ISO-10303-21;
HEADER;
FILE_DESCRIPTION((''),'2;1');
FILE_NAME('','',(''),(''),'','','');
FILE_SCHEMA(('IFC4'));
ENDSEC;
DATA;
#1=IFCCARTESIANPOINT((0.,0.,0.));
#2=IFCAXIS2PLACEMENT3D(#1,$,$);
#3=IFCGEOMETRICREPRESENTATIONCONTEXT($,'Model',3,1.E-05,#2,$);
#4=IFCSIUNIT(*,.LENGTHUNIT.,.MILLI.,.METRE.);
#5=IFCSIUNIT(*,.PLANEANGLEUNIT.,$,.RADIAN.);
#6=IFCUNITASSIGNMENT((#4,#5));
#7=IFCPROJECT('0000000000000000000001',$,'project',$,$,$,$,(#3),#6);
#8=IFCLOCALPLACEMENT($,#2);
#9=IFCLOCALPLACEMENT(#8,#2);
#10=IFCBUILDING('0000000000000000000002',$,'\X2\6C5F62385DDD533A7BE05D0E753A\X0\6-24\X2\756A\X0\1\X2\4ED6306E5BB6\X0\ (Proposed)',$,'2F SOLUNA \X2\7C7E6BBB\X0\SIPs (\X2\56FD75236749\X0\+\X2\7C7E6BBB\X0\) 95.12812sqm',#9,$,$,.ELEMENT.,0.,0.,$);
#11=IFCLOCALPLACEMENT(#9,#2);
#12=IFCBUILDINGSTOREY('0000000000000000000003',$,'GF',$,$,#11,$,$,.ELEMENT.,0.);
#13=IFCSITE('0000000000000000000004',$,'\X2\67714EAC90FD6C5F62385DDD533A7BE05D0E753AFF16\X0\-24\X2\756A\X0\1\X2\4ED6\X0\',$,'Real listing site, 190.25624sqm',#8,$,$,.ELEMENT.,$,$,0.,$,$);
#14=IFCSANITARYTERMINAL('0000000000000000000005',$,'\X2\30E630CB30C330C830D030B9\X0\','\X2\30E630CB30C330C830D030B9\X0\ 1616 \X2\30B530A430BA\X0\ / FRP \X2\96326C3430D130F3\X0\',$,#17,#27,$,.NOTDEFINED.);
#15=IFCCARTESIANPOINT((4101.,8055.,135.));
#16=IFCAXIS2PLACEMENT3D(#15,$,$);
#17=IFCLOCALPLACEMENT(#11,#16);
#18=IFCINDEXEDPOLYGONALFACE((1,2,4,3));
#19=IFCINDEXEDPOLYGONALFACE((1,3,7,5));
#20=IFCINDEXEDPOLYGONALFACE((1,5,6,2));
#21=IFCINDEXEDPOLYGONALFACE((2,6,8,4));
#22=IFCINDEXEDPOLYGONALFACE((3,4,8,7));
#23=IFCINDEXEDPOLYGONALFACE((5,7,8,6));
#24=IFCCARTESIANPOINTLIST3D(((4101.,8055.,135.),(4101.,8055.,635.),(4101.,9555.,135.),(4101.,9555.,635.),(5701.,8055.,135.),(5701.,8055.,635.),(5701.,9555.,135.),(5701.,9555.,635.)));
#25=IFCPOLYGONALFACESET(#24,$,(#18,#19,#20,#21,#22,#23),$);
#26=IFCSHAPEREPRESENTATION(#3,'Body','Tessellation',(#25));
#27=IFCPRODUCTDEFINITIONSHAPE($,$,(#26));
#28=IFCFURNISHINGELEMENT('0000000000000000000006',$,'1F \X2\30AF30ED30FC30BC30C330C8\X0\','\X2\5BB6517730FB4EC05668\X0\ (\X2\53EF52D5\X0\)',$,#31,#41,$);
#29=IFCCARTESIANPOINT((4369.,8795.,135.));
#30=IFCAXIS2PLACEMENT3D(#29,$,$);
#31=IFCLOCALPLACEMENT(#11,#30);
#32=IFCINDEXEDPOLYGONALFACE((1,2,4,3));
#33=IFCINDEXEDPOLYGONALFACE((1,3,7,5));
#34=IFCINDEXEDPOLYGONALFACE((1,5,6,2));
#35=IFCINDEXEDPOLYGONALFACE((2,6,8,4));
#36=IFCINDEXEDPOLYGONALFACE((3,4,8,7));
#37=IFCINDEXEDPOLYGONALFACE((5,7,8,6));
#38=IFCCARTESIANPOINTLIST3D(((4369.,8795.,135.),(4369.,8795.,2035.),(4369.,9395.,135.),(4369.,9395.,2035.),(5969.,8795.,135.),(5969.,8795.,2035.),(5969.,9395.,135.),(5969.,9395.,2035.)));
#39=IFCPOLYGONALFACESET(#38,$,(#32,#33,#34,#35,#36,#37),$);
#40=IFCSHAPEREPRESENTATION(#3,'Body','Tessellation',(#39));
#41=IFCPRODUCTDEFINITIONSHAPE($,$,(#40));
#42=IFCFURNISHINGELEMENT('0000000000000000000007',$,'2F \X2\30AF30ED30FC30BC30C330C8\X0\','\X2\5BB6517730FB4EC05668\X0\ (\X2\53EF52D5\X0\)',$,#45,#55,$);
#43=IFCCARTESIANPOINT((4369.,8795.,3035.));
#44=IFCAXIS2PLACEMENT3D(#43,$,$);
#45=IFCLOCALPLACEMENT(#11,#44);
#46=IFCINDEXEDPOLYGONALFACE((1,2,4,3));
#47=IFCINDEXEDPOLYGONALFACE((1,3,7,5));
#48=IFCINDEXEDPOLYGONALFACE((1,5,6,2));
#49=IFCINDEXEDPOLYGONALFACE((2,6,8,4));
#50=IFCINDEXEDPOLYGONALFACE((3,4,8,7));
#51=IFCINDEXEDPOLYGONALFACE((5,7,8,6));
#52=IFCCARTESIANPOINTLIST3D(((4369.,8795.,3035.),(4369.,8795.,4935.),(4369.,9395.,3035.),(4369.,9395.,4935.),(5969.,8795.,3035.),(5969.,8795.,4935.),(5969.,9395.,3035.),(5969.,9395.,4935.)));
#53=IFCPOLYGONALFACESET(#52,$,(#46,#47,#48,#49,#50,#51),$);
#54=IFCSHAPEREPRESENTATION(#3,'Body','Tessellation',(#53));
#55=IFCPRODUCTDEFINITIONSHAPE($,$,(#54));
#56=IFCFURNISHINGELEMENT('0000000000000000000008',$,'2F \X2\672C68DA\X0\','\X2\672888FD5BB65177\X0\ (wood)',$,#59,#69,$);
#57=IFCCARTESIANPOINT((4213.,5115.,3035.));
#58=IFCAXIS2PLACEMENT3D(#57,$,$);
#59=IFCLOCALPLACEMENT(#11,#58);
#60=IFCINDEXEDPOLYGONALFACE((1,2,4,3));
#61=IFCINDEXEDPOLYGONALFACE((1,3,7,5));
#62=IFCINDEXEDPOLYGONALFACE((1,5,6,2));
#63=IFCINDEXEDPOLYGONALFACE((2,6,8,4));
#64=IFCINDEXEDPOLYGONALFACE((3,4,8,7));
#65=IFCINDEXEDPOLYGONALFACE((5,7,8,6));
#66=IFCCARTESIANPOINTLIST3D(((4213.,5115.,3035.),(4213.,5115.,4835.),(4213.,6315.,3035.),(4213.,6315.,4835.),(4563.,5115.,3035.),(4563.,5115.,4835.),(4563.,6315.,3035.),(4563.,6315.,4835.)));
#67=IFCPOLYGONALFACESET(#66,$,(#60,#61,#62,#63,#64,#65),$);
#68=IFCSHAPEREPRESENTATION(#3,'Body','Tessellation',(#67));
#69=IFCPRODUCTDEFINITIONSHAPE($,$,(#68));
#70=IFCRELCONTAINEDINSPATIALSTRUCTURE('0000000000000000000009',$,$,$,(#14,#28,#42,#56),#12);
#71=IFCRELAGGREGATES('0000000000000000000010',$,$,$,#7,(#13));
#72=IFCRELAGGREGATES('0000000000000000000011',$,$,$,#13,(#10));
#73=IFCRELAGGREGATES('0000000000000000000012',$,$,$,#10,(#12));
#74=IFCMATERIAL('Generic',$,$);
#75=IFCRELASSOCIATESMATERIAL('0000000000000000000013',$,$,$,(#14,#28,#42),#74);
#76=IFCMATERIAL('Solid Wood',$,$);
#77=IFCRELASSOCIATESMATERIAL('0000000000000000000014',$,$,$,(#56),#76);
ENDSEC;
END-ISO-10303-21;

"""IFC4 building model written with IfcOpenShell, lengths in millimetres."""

from ifc_helpers import new_model, si_unit, frame, frame_2d, origin, place, context, project, spatial, rectangle, extrude, material, element, save


model = new_model("IFC4")

# Units and contexts
model_context = context("Model", 3, precision=1e-05, world=origin())
ifc_project = project(units=[si_unit("LENGTHUNIT", "METRE", prefix="MILLI"), si_unit("PLANEANGLEUNIT", "RADIAN")], contexts=[model_context])

# Site, building, storey
site_placement = place(None, origin())
site = spatial("IfcSite", under=ifc_project, at=site_placement, Name="東京都江戸川区篠崎町６-24番1他", ObjectType="Real listing site, 190.25624sqm", CompositionType="ELEMENT", RefElevation=0.0)
building_placement = place(site_placement, origin())
building = spatial("IfcBuilding", under=site, at=building_placement, Name="江戸川区篠崎町6-24番1他の家 (Proposed)", ObjectType="2F SOLUNA 籾殻SIPs (国産杉+籾殻) 95.12812sqm", CompositionType="ELEMENT", ElevationOfRefHeight=0.0, ElevationOfTerrain=0.0)
storey_placement = place(building_placement, origin())
storey = spatial("IfcBuildingStorey", under=building, at=storey_placement, Name="GF", CompositionType="ELEMENT", Elevation=0.0)

# Shared definitions
ifc_material_1 = material(Name="Solid Wood")

# Shared definitions
ifc_material_2 = material(Name="Generic")

# Sanitary terminal
sanitary_terminal_placement = place(storey_placement, frame((4101.0, 8055.0, 135.0)))
element("IfcSanitaryTerminal", 1, at=sanitary_terminal_placement, inside=storey, material=ifc_material_2, Name="ユニットバス", Description="ユニットバス 1616 サイズ / FRP 防水パン", PredefinedType="NOTDEFINED", context=model_context, shape_type="SweptSolid", body=[
    extrude(rectangle(XDim=1600.0, YDim=1500.0, at=frame_2d((800.0, 750.0))), frame((4101.0, 8055.0, 135.0)), (0.0, 0.0, 1.0), 500.0),
])

# Furnishing elements
furnishing_1_placement = place(storey_placement, frame((4369.0, 8795.0, 135.0)))
element("IfcFurnishingElement", 2, at=furnishing_1_placement, inside=storey, material=ifc_material_2, Name="1F クローゼット", Description="家具・什器 (可動)", context=model_context, shape_type="SweptSolid", body=[
    extrude(rectangle(XDim=1600.0, YDim=600.0, at=frame_2d((800.0, 300.0))), frame((4369.0, 8795.0, 135.0)), (0.0, 0.0, 1.0), 1900.0),
])
furnishing_2_placement = place(storey_placement, frame((4369.0, 8795.0, 3035.0)))
element("IfcFurnishingElement", 3, at=furnishing_2_placement, inside=storey, material=ifc_material_2, Name="2F クローゼット", Description="家具・什器 (可動)", context=model_context, shape_type="SweptSolid", body=[
    extrude(rectangle(XDim=1600.0, YDim=600.0, at=frame_2d((800.0, 300.0))), frame((4369.0, 8795.0, 3035.0)), (0.0, 0.0, 1.0), 1900.0),
])
furnishing_3_placement = place(storey_placement, frame((4213.0, 5115.0, 3035.0)))
element("IfcFurnishingElement", 4, at=furnishing_3_placement, inside=storey, material=ifc_material_1, Name="2F 本棚", Description="木製家具 (wood)", context=model_context, shape_type="SweptSolid", body=[
    extrude(rectangle(XDim=350.0, YDim=1200.0, at=frame_2d((175.0, 600.0))), frame((4213.0, 5115.0, 3035.0)), (0.0, 0.0, 1.0), 1800.0),
])

save(model, "model.ifc")
